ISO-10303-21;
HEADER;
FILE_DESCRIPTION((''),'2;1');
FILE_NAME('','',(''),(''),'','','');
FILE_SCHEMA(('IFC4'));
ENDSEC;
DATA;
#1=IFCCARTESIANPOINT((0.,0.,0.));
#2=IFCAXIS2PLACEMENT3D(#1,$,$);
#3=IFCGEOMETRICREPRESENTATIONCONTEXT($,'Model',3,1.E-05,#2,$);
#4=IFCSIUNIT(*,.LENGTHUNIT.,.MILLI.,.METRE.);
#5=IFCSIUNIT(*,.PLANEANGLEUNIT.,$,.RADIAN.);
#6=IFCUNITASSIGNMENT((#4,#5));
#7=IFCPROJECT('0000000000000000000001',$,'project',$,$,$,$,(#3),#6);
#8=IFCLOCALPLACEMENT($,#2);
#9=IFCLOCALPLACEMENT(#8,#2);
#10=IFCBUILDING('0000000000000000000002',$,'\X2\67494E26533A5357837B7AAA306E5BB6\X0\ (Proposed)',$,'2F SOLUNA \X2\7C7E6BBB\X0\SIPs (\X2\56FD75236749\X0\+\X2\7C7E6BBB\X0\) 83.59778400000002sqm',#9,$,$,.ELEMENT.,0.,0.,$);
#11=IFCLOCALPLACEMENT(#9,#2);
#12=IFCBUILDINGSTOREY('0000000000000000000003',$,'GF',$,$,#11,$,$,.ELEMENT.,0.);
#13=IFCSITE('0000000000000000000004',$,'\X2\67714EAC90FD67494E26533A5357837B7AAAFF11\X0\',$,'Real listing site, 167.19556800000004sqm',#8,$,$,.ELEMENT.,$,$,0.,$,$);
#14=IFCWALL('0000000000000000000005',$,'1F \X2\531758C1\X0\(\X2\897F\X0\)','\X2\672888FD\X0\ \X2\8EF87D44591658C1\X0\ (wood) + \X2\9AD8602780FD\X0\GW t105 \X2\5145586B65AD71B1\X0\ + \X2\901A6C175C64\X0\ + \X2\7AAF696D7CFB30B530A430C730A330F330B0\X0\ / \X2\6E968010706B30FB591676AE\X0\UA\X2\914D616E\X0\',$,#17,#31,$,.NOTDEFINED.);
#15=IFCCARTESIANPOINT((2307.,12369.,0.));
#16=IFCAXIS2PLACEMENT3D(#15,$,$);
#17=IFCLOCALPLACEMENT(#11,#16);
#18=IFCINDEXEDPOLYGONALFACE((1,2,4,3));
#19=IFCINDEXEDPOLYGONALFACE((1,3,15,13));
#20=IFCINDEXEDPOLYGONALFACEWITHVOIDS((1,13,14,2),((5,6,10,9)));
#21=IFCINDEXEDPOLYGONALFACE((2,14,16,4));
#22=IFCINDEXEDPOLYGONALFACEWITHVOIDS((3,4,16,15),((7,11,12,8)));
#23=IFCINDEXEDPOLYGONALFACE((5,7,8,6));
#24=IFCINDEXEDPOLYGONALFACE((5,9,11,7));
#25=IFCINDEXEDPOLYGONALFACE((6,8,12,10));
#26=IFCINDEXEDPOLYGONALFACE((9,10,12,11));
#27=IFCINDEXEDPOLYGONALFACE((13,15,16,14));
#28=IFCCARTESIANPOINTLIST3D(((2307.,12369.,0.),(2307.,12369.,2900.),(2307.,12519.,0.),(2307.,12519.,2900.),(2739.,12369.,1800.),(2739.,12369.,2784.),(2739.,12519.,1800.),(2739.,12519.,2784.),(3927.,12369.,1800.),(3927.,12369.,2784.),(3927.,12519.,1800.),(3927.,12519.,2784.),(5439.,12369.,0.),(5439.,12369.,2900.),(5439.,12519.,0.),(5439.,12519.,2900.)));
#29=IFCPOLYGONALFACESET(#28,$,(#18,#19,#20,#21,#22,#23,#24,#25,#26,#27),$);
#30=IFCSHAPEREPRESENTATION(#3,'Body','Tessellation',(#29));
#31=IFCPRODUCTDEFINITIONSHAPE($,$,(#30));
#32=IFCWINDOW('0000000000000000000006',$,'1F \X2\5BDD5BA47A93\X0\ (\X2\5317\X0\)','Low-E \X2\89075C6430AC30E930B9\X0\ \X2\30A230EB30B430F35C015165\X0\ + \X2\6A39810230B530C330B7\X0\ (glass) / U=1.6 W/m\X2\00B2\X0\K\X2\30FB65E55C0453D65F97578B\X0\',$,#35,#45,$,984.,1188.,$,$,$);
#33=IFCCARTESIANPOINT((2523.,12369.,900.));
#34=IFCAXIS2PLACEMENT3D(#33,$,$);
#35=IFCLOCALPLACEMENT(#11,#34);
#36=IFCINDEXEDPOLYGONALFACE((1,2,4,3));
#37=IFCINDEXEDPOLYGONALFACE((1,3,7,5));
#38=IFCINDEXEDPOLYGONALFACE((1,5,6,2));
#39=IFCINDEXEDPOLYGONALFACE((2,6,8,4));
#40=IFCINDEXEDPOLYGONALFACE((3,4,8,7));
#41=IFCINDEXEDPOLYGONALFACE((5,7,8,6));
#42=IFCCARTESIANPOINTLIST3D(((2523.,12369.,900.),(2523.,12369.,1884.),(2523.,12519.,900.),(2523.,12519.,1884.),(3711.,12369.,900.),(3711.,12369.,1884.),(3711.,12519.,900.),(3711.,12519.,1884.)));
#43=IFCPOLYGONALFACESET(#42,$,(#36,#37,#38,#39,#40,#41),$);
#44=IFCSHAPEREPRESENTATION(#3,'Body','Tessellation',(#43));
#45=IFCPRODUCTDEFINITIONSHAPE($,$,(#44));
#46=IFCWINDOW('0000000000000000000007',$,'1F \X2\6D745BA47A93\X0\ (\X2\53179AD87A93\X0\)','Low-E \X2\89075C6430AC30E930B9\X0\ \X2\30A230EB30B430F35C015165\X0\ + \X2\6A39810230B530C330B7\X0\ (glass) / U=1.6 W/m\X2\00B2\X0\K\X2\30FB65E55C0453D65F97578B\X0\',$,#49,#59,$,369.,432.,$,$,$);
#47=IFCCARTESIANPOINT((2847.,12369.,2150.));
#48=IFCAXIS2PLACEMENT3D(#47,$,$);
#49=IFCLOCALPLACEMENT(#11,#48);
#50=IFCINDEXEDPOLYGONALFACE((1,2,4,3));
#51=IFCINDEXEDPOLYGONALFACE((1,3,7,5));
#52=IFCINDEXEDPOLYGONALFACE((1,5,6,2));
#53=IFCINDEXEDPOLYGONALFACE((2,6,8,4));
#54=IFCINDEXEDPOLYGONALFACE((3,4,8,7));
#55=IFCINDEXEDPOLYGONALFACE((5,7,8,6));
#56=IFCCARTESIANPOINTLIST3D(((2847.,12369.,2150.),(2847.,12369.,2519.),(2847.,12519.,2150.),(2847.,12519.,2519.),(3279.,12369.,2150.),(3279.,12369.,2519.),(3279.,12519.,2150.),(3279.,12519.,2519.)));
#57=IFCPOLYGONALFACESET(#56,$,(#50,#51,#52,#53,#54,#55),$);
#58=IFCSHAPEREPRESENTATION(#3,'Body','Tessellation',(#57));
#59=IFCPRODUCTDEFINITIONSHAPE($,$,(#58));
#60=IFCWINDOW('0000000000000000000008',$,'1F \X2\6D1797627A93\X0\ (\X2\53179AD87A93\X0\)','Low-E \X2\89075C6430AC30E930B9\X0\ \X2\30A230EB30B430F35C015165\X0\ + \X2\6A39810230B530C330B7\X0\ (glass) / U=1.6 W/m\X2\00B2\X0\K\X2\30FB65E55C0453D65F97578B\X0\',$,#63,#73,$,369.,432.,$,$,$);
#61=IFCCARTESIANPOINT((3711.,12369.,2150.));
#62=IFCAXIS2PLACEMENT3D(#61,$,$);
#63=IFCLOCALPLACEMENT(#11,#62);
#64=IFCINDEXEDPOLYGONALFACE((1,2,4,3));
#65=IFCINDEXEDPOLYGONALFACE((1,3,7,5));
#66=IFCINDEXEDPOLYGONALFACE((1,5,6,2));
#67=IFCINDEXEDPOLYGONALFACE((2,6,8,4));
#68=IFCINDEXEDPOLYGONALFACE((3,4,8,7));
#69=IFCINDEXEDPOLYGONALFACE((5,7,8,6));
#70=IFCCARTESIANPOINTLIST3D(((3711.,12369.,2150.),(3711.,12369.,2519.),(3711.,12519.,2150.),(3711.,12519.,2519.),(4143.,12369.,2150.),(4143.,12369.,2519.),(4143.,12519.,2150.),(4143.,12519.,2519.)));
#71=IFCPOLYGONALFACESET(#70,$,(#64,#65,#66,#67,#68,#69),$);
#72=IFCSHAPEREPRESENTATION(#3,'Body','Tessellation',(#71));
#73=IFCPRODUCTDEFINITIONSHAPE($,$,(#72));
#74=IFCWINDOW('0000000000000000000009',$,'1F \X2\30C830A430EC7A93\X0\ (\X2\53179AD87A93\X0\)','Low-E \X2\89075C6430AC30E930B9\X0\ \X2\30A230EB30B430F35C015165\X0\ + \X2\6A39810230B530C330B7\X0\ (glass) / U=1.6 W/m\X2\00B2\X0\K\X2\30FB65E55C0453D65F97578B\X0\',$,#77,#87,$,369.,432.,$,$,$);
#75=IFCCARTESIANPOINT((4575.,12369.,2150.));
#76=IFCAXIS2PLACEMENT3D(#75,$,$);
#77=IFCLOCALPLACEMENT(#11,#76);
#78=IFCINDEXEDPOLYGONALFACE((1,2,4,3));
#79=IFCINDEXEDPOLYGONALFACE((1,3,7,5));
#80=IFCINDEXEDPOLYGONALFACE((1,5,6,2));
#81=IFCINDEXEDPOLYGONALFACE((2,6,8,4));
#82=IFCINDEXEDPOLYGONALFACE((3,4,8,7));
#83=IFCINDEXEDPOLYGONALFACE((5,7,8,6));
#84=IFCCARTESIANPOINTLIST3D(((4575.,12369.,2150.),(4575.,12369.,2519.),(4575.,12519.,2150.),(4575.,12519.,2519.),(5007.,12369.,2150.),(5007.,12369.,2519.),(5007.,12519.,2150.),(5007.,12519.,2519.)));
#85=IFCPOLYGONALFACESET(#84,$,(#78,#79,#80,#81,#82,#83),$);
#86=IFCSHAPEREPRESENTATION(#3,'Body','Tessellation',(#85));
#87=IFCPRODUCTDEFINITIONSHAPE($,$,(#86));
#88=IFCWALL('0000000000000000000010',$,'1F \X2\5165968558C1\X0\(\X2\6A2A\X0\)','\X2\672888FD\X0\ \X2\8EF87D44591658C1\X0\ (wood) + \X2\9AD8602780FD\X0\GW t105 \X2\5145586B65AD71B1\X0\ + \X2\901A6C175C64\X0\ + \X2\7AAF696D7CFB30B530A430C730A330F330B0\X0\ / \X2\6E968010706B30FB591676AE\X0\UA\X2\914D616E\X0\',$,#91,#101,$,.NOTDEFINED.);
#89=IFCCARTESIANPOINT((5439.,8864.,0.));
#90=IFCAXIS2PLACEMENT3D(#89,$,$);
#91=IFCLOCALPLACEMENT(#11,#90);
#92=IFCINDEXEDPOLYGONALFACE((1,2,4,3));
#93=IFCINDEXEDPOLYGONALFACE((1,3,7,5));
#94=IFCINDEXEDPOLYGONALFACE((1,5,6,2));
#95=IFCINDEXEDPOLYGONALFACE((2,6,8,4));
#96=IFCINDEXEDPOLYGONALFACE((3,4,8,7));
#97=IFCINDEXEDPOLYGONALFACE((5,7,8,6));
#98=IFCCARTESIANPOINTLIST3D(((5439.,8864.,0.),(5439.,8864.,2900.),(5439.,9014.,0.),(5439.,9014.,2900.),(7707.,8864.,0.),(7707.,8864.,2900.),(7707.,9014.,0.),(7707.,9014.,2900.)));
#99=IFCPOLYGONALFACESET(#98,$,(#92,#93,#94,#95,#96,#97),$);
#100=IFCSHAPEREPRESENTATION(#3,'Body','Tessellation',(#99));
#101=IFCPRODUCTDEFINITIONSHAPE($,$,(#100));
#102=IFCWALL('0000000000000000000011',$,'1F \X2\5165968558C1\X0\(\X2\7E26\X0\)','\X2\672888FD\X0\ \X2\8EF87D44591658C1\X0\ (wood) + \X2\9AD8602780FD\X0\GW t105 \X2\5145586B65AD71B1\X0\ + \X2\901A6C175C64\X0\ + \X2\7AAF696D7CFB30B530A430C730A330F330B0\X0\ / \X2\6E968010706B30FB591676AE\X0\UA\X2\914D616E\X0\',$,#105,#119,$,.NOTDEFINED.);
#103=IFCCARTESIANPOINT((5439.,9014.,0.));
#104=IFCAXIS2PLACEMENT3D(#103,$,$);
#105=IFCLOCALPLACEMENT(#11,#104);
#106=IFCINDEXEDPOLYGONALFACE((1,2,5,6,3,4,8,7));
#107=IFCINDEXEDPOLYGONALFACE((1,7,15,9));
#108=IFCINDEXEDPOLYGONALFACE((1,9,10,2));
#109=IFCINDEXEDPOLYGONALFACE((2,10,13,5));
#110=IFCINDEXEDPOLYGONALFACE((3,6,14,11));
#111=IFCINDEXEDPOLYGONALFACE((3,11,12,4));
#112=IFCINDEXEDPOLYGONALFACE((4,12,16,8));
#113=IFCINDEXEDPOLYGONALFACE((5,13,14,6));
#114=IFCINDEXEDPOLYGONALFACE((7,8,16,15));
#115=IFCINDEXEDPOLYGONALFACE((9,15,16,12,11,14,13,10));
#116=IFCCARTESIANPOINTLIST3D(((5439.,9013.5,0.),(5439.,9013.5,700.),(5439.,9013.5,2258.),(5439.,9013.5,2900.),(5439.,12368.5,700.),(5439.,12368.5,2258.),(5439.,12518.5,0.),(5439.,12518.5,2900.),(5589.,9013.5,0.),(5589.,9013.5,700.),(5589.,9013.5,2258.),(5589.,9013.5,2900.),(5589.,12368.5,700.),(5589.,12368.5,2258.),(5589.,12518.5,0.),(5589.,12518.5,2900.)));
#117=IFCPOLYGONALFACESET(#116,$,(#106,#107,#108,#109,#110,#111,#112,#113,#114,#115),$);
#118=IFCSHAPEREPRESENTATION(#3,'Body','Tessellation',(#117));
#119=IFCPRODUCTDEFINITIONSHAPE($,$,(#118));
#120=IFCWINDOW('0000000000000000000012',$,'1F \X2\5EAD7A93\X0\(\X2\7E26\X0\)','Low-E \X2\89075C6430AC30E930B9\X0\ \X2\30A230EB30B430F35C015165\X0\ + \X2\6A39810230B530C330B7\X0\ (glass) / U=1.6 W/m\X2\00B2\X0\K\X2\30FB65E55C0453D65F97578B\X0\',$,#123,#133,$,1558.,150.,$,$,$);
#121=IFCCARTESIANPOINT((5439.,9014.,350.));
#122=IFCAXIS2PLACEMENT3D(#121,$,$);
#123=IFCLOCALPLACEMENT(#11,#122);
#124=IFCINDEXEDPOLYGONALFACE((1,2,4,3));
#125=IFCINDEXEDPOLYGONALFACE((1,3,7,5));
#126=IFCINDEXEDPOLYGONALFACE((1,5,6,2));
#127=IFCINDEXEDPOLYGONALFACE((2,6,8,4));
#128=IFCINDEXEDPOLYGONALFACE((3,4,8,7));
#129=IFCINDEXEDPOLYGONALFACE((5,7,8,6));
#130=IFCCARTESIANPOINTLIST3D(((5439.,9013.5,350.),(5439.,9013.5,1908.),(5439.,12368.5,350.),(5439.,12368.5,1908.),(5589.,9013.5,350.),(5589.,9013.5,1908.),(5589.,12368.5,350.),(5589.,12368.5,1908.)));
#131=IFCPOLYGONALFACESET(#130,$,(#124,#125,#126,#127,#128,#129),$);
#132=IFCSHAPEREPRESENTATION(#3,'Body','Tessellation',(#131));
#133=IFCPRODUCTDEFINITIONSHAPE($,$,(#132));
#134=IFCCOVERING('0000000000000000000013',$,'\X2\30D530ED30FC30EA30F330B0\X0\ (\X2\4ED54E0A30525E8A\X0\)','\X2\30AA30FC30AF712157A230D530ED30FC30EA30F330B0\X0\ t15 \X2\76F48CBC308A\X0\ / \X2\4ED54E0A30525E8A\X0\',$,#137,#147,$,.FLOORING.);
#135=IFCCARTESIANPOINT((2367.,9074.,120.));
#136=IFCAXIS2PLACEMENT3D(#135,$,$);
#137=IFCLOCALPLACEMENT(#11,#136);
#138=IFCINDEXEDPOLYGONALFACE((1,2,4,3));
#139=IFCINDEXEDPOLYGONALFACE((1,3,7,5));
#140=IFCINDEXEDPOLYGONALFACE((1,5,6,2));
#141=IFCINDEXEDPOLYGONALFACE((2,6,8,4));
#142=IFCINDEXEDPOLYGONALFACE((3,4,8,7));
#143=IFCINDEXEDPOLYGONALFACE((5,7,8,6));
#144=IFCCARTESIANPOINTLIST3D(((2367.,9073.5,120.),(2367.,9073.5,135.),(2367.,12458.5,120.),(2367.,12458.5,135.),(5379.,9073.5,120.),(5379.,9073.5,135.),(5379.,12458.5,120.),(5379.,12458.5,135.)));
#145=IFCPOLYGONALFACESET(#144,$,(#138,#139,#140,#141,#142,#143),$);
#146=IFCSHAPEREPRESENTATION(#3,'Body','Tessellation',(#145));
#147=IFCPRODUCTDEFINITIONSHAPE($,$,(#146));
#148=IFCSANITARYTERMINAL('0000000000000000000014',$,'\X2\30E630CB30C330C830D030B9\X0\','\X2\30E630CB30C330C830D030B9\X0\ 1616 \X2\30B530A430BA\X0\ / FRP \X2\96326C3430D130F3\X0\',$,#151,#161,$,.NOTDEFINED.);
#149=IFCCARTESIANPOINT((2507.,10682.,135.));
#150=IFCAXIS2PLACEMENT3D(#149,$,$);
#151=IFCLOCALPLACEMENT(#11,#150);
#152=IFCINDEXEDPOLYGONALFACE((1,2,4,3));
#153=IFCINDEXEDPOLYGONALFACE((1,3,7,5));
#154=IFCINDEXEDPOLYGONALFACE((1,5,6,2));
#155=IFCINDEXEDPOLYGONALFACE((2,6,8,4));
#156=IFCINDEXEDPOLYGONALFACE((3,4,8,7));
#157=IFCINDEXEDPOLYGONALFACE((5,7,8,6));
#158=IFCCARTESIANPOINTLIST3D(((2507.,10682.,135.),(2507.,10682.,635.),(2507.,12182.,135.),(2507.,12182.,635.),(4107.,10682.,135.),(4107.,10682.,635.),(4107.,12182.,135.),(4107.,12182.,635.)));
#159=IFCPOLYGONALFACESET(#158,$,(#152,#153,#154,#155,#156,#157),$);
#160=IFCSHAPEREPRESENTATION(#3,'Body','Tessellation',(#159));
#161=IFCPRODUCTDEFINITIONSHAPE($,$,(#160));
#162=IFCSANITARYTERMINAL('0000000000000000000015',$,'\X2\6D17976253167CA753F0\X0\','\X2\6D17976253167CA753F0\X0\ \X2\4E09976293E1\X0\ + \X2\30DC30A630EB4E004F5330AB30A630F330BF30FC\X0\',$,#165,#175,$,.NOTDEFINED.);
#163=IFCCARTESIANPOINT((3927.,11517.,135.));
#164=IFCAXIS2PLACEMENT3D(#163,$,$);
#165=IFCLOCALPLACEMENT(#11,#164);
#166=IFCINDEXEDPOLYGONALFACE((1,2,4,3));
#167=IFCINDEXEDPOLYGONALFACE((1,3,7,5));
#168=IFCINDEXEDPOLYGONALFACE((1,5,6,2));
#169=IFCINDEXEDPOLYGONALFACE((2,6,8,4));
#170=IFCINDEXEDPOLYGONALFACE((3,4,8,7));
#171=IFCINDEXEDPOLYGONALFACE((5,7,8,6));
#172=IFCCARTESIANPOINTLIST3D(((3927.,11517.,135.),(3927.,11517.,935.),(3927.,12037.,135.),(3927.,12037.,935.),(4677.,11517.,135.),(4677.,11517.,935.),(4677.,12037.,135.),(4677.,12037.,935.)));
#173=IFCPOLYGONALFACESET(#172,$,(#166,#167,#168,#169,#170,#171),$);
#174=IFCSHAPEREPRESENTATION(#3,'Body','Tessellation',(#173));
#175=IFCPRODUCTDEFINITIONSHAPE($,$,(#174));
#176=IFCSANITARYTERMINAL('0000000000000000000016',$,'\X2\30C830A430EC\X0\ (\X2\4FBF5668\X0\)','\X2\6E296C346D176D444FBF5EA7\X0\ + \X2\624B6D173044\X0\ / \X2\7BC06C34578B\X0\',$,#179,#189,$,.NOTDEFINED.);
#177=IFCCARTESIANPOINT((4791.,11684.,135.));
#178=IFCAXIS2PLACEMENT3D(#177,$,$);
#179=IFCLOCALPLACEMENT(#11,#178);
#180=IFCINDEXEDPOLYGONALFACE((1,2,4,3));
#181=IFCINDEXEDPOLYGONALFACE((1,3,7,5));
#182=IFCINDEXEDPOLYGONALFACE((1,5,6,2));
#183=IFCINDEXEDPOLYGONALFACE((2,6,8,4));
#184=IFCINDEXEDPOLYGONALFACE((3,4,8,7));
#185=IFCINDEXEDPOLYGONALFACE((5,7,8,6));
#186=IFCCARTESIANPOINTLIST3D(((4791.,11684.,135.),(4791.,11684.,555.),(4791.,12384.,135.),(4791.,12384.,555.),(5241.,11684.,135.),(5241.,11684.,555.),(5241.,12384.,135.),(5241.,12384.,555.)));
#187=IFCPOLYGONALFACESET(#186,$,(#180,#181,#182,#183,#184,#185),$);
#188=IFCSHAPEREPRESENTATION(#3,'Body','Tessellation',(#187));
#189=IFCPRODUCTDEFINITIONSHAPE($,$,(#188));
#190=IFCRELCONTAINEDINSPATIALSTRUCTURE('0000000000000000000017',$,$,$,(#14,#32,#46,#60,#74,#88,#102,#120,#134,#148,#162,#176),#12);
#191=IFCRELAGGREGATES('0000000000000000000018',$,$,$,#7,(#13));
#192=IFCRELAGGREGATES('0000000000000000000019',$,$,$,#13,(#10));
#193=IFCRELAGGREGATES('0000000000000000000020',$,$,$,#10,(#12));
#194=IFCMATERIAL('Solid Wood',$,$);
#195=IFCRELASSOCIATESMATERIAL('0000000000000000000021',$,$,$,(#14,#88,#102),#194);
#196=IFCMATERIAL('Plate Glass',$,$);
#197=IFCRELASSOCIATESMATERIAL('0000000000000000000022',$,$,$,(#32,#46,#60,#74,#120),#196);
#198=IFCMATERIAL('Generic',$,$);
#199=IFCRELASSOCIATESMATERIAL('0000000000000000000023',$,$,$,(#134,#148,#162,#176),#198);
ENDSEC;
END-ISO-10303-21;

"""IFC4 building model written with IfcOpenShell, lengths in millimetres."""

from ifc_helpers import new_model, si_unit, frame, frame_2d, origin, place, context, project, spatial, rectangle, extrude, material, element, fill, save


model = new_model("IFC4")

# Units and contexts
model_context = context("Model", 3, precision=1e-05, world=origin())
ifc_project = project(units=[si_unit("LENGTHUNIT", "METRE", prefix="MILLI"), si_unit("PLANEANGLEUNIT", "RADIAN")], contexts=[model_context])

# Site, building, storey
site_placement = place(None, origin())
site = spatial("IfcSite", under=ifc_project, at=site_placement, Name="東京都杉並区南荻窪１", ObjectType="Real listing site, 167.19556800000004sqm", CompositionType="ELEMENT", RefElevation=0.0)
building_placement = place(site_placement, origin())
building = spatial("IfcBuilding", under=site, at=building_placement, Name="杉並区南荻窪の家 (Proposed)", ObjectType="2F SOLUNA 籾殻SIPs (国産杉+籾殻) 83.59778400000002sqm", CompositionType="ELEMENT", ElevationOfRefHeight=0.0, ElevationOfTerrain=0.0)
storey_placement = place(building_placement, origin())
storey = spatial("IfcBuildingStorey", under=building, at=storey_placement, Name="GF", CompositionType="ELEMENT", Elevation=0.0)

# Shared definitions
ifc_material_1 = material(Name="Solid Wood")

# Wall, openings, windows
wall_1_placement = place(storey_placement, frame((2307.0, 12369.0, 0.0)))
wall_1 = element("IfcWall", 1, at=wall_1_placement, inside=storey, material=ifc_material_1, Name="1F 北壁(西)", Description="木製 軸組外壁 (wood) + 高性能GW t105 充填断熱 + 通気層 + 窯業系サイディング / 準耐火・外皮UA配慮", PredefinedType="NOTDEFINED", context=model_context, shape_type="SweptSolid", body=[
    extrude(rectangle(XDim=3132.0, YDim=150.0, at=frame_2d((1566.0, 75.0))), frame((2307.0, 12369.0, 0.0)), (0.0, 0.0, 1.0), 2900.0),
])
opening_1_placement = place(storey_placement, frame((2523.0, 12369.0, 900.0)))
opening_1 = element("IfcOpeningElement", 2, at=opening_1_placement, cuts=wall_1, PredefinedType="NOTDEFINED", context=model_context, shape_type="SweptSolid", body=[
    extrude(rectangle(XDim=1188.0, YDim=150.0, at=frame_2d((594.0, 75.0))), frame((2523.0, 12369.0, 900.0)), (0.0, 0.0, 1.0), 984.0),
])
opening_2_placement = place(storey_placement, frame((2847.0, 12369.0, 2150.0)))
opening_2 = element("IfcOpeningElement", 3, at=opening_2_placement, cuts=wall_1, PredefinedType="NOTDEFINED", context=model_context, shape_type="SweptSolid", body=[
    extrude(rectangle(XDim=432.0, YDim=150.0, at=frame_2d((216.0, 75.0))), frame((2847.0, 12369.0, 2150.0)), (0.0, 0.0, 1.0), 369.0),
])
opening_3_placement = place(storey_placement, frame((3711.0, 12369.0, 2150.0)))
opening_3 = element("IfcOpeningElement", 4, at=opening_3_placement, cuts=wall_1, PredefinedType="NOTDEFINED", context=model_context, shape_type="SweptSolid", body=[
    extrude(rectangle(XDim=432.0, YDim=150.0, at=frame_2d((216.0, 75.0))), frame((3711.0, 12369.0, 2150.0)), (0.0, 0.0, 1.0), 369.0),
])
opening_4_placement = place(storey_placement, frame((4575.0, 12369.0, 2150.0)))
opening_4 = element("IfcOpeningElement", 5, at=opening_4_placement, cuts=wall_1, PredefinedType="NOTDEFINED", context=model_context, shape_type="SweptSolid", body=[
    extrude(rectangle(XDim=432.0, YDim=150.0, at=frame_2d((216.0, 75.0))), frame((4575.0, 12369.0, 2150.0)), (0.0, 0.0, 1.0), 369.0),
])
ifc_material_2 = material(Name="Plate Glass")
window_1_placement = place(storey_placement, frame((2523.0, 12369.0, 900.0)))
window_1 = element("IfcWindow", 6, at=window_1_placement, inside=storey, material=ifc_material_2, Name="1F 寝室窓 (北)", Description="Low-E 複層ガラス アルゴン封入 + 樹脂サッシ (glass) / U=1.6 W/m²K・日射取得型", OverallHeight=984.0, OverallWidth=1188.0, context=model_context, shape_type="SweptSolid", body=[
    extrude(rectangle(XDim=1188.0, YDim=150.0, at=frame_2d((594.0, 75.0))), frame((2523.0, 12369.0, 900.0)), (0.0, 0.0, 1.0), 984.0),
])
fill(opening_1, window_1)
window_2_placement = place(storey_placement, frame((2847.0, 12369.0, 2150.0)))
window_2 = element("IfcWindow", 7, at=window_2_placement, inside=storey, material=ifc_material_2, Name="1F 浴室窓 (北高窓)", Description="Low-E 複層ガラス アルゴン封入 + 樹脂サッシ (glass) / U=1.6 W/m²K・日射取得型", OverallHeight=369.0, OverallWidth=432.0, context=model_context, shape_type="SweptSolid", body=[
    extrude(rectangle(XDim=432.0, YDim=150.0, at=frame_2d((216.0, 75.0))), frame((2847.0, 12369.0, 2150.0)), (0.0, 0.0, 1.0), 369.0),
])
fill(opening_2, window_2)
window_3_placement = place(storey_placement, frame((3711.0, 12369.0, 2150.0)))
window_3 = element("IfcWindow", 8, at=window_3_placement, inside=storey, material=ifc_material_2, Name="1F 洗面窓 (北高窓)", Description="Low-E 複層ガラス アルゴン封入 + 樹脂サッシ (glass) / U=1.6 W/m²K・日射取得型", OverallHeight=369.0, OverallWidth=432.0, context=model_context, shape_type="SweptSolid", body=[
    extrude(rectangle(XDim=432.0, YDim=150.0, at=frame_2d((216.0, 75.0))), frame((3711.0, 12369.0, 2150.0)), (0.0, 0.0, 1.0), 369.0),
])
fill(opening_3, window_3)
window_4_placement = place(storey_placement, frame((4575.0, 12369.0, 2150.0)))
window_4 = element("IfcWindow", 9, at=window_4_placement, inside=storey, material=ifc_material_2, Name="1F トイレ窓 (北高窓)", Description="Low-E 複層ガラス アルゴン封入 + 樹脂サッシ (glass) / U=1.6 W/m²K・日射取得型", OverallHeight=369.0, OverallWidth=432.0, context=model_context, shape_type="SweptSolid", body=[
    extrude(rectangle(XDim=432.0, YDim=150.0, at=frame_2d((216.0, 75.0))), frame((4575.0, 12369.0, 2150.0)), (0.0, 0.0, 1.0), 369.0),
])
fill(opening_4, window_4)

# Wall
wall_2_placement = place(storey_placement, frame((5439.0, 8864.0, 0.0)))
element("IfcWall", 10, at=wall_2_placement, inside=storey, material=ifc_material_1, Name="1F 入隅壁(横)", Description="木製 軸組外壁 (wood) + 高性能GW t105 充填断熱 + 通気層 + 窯業系サイディング / 準耐火・外皮UA配慮", PredefinedType="NOTDEFINED", context=model_context, shape_type="SweptSolid", body=[
    extrude(rectangle(XDim=2268.0, YDim=150.0, at=frame_2d((1134.0, 75.0))), frame((5439.0, 8864.0, 0.0)), (0.0, 0.0, 1.0), 2900.0),
])

# Wall, opening, window
wall_3_placement = place(storey_placement, frame((5439.0, 9014.0, 0.0)))
wall_3 = element("IfcWall", 11, at=wall_3_placement, inside=storey, material=ifc_material_1, Name="1F 入隅壁(縦)", Description="木製 軸組外壁 (wood) + 高性能GW t105 充填断熱 + 通気層 + 窯業系サイディング / 準耐火・外皮UA配慮", PredefinedType="NOTDEFINED", context=model_context, shape_type="SweptSolid", body=[
    extrude(rectangle(XDim=150.0, YDim=3505.0, at=frame_2d((75.0, 1752.0))), frame((5439.0, 9014.0, 0.0)), (0.0, 0.0, 1.0), 2900.0),
])
opening_5_placement = place(storey_placement, frame((5439.0, 9014.0, 350.0)))
opening_5 = element("IfcOpeningElement", 12, at=opening_5_placement, cuts=wall_3, PredefinedType="NOTDEFINED", context=model_context, shape_type="SweptSolid", body=[
    extrude(rectangle(XDim=150.0, YDim=3355.0, at=frame_2d((75.0, 1677.0))), frame((5439.0, 9014.0, 350.0)), (0.0, 0.0, 1.0), 1558.0),
])
window_5_placement = place(storey_placement, frame((5439.0, 9014.0, 350.0)))
window_5 = element("IfcWindow", 13, at=window_5_placement, inside=storey, material=ifc_material_2, Name="1F 庭窓(縦)", Description="Low-E 複層ガラス アルゴン封入 + 樹脂サッシ (glass) / U=1.6 W/m²K・日射取得型", OverallHeight=1558.0, OverallWidth=150.0, context=model_context, shape_type="SweptSolid", body=[
    extrude(rectangle(XDim=150.0, YDim=3355.0, at=frame_2d((75.0, 1677.0))), frame((5439.0, 9014.0, 350.0)), (0.0, 0.0, 1.0), 1558.0),
])
fill(opening_5, window_5)

# Covering
ifc_material_3 = material(Name="Generic")
covering_placement = place(storey_placement, frame((2367.0, 9074.0, 120.0)))
element("IfcCovering", 14, at=covering_placement, inside=storey, material=ifc_material_3, Name="フローリング (仕上げ床)", Description="オーク無垢フローリング t15 直貼り / 仕上げ床", PredefinedType="FLOORING", context=model_context, shape_type="SweptSolid", body=[
    extrude(rectangle(XDim=3012.0, YDim=3385.0, at=frame_2d((1506.0, 1692.0))), frame((2367.0, 9074.0, 120.0)), (0.0, 0.0, 1.0), 15.0),
])

# Sanitary terminals
sanitary_terminal_1_placement = place(storey_placement, frame((2507.0, 10682.0, 135.0)))
element("IfcSanitaryTerminal", 15, at=sanitary_terminal_1_placement, inside=storey, material=ifc_material_3, Name="ユニットバス", Description="ユニットバス 1616 サイズ / FRP 防水パン", PredefinedType="NOTDEFINED", context=model_context, shape_type="SweptSolid", body=[
    extrude(rectangle(XDim=1600.0, YDim=1500.0, at=frame_2d((800.0, 750.0))), frame((2507.0, 10682.0, 135.0)), (0.0, 0.0, 1.0), 500.0),
])
sanitary_terminal_2_placement = place(storey_placement, frame((3927.0, 11517.0, 135.0)))
element("IfcSanitaryTerminal", 16, at=sanitary_terminal_2_placement, inside=storey, material=ifc_material_3, Name="洗面化粧台", Description="洗面化粧台 三面鏡 + ボウル一体カウンター", PredefinedType="NOTDEFINED", context=model_context, shape_type="SweptSolid", body=[
    extrude(rectangle(XDim=750.0, YDim=520.0, at=frame_2d((375.0, 260.0))), frame((3927.0, 11517.0, 135.0)), (0.0, 0.0, 1.0), 800.0),
])
sanitary_terminal_3_placement = place(storey_placement, frame((4791.0, 11684.0, 135.0)))
element("IfcSanitaryTerminal", 17, at=sanitary_terminal_3_placement, inside=storey, material=ifc_material_3, Name="トイレ (便器)", Description="温水洗浄便座 + 手洗い / 節水型", PredefinedType="NOTDEFINED", context=model_context, shape_type="SweptSolid", body=[
    extrude(rectangle(XDim=450.0, YDim=700.0, at=frame_2d((225.0, 350.0))), frame((4791.0, 11684.0, 135.0)), (0.0, 0.0, 1.0), 420.0),
])

save(model, "model.ifc")
